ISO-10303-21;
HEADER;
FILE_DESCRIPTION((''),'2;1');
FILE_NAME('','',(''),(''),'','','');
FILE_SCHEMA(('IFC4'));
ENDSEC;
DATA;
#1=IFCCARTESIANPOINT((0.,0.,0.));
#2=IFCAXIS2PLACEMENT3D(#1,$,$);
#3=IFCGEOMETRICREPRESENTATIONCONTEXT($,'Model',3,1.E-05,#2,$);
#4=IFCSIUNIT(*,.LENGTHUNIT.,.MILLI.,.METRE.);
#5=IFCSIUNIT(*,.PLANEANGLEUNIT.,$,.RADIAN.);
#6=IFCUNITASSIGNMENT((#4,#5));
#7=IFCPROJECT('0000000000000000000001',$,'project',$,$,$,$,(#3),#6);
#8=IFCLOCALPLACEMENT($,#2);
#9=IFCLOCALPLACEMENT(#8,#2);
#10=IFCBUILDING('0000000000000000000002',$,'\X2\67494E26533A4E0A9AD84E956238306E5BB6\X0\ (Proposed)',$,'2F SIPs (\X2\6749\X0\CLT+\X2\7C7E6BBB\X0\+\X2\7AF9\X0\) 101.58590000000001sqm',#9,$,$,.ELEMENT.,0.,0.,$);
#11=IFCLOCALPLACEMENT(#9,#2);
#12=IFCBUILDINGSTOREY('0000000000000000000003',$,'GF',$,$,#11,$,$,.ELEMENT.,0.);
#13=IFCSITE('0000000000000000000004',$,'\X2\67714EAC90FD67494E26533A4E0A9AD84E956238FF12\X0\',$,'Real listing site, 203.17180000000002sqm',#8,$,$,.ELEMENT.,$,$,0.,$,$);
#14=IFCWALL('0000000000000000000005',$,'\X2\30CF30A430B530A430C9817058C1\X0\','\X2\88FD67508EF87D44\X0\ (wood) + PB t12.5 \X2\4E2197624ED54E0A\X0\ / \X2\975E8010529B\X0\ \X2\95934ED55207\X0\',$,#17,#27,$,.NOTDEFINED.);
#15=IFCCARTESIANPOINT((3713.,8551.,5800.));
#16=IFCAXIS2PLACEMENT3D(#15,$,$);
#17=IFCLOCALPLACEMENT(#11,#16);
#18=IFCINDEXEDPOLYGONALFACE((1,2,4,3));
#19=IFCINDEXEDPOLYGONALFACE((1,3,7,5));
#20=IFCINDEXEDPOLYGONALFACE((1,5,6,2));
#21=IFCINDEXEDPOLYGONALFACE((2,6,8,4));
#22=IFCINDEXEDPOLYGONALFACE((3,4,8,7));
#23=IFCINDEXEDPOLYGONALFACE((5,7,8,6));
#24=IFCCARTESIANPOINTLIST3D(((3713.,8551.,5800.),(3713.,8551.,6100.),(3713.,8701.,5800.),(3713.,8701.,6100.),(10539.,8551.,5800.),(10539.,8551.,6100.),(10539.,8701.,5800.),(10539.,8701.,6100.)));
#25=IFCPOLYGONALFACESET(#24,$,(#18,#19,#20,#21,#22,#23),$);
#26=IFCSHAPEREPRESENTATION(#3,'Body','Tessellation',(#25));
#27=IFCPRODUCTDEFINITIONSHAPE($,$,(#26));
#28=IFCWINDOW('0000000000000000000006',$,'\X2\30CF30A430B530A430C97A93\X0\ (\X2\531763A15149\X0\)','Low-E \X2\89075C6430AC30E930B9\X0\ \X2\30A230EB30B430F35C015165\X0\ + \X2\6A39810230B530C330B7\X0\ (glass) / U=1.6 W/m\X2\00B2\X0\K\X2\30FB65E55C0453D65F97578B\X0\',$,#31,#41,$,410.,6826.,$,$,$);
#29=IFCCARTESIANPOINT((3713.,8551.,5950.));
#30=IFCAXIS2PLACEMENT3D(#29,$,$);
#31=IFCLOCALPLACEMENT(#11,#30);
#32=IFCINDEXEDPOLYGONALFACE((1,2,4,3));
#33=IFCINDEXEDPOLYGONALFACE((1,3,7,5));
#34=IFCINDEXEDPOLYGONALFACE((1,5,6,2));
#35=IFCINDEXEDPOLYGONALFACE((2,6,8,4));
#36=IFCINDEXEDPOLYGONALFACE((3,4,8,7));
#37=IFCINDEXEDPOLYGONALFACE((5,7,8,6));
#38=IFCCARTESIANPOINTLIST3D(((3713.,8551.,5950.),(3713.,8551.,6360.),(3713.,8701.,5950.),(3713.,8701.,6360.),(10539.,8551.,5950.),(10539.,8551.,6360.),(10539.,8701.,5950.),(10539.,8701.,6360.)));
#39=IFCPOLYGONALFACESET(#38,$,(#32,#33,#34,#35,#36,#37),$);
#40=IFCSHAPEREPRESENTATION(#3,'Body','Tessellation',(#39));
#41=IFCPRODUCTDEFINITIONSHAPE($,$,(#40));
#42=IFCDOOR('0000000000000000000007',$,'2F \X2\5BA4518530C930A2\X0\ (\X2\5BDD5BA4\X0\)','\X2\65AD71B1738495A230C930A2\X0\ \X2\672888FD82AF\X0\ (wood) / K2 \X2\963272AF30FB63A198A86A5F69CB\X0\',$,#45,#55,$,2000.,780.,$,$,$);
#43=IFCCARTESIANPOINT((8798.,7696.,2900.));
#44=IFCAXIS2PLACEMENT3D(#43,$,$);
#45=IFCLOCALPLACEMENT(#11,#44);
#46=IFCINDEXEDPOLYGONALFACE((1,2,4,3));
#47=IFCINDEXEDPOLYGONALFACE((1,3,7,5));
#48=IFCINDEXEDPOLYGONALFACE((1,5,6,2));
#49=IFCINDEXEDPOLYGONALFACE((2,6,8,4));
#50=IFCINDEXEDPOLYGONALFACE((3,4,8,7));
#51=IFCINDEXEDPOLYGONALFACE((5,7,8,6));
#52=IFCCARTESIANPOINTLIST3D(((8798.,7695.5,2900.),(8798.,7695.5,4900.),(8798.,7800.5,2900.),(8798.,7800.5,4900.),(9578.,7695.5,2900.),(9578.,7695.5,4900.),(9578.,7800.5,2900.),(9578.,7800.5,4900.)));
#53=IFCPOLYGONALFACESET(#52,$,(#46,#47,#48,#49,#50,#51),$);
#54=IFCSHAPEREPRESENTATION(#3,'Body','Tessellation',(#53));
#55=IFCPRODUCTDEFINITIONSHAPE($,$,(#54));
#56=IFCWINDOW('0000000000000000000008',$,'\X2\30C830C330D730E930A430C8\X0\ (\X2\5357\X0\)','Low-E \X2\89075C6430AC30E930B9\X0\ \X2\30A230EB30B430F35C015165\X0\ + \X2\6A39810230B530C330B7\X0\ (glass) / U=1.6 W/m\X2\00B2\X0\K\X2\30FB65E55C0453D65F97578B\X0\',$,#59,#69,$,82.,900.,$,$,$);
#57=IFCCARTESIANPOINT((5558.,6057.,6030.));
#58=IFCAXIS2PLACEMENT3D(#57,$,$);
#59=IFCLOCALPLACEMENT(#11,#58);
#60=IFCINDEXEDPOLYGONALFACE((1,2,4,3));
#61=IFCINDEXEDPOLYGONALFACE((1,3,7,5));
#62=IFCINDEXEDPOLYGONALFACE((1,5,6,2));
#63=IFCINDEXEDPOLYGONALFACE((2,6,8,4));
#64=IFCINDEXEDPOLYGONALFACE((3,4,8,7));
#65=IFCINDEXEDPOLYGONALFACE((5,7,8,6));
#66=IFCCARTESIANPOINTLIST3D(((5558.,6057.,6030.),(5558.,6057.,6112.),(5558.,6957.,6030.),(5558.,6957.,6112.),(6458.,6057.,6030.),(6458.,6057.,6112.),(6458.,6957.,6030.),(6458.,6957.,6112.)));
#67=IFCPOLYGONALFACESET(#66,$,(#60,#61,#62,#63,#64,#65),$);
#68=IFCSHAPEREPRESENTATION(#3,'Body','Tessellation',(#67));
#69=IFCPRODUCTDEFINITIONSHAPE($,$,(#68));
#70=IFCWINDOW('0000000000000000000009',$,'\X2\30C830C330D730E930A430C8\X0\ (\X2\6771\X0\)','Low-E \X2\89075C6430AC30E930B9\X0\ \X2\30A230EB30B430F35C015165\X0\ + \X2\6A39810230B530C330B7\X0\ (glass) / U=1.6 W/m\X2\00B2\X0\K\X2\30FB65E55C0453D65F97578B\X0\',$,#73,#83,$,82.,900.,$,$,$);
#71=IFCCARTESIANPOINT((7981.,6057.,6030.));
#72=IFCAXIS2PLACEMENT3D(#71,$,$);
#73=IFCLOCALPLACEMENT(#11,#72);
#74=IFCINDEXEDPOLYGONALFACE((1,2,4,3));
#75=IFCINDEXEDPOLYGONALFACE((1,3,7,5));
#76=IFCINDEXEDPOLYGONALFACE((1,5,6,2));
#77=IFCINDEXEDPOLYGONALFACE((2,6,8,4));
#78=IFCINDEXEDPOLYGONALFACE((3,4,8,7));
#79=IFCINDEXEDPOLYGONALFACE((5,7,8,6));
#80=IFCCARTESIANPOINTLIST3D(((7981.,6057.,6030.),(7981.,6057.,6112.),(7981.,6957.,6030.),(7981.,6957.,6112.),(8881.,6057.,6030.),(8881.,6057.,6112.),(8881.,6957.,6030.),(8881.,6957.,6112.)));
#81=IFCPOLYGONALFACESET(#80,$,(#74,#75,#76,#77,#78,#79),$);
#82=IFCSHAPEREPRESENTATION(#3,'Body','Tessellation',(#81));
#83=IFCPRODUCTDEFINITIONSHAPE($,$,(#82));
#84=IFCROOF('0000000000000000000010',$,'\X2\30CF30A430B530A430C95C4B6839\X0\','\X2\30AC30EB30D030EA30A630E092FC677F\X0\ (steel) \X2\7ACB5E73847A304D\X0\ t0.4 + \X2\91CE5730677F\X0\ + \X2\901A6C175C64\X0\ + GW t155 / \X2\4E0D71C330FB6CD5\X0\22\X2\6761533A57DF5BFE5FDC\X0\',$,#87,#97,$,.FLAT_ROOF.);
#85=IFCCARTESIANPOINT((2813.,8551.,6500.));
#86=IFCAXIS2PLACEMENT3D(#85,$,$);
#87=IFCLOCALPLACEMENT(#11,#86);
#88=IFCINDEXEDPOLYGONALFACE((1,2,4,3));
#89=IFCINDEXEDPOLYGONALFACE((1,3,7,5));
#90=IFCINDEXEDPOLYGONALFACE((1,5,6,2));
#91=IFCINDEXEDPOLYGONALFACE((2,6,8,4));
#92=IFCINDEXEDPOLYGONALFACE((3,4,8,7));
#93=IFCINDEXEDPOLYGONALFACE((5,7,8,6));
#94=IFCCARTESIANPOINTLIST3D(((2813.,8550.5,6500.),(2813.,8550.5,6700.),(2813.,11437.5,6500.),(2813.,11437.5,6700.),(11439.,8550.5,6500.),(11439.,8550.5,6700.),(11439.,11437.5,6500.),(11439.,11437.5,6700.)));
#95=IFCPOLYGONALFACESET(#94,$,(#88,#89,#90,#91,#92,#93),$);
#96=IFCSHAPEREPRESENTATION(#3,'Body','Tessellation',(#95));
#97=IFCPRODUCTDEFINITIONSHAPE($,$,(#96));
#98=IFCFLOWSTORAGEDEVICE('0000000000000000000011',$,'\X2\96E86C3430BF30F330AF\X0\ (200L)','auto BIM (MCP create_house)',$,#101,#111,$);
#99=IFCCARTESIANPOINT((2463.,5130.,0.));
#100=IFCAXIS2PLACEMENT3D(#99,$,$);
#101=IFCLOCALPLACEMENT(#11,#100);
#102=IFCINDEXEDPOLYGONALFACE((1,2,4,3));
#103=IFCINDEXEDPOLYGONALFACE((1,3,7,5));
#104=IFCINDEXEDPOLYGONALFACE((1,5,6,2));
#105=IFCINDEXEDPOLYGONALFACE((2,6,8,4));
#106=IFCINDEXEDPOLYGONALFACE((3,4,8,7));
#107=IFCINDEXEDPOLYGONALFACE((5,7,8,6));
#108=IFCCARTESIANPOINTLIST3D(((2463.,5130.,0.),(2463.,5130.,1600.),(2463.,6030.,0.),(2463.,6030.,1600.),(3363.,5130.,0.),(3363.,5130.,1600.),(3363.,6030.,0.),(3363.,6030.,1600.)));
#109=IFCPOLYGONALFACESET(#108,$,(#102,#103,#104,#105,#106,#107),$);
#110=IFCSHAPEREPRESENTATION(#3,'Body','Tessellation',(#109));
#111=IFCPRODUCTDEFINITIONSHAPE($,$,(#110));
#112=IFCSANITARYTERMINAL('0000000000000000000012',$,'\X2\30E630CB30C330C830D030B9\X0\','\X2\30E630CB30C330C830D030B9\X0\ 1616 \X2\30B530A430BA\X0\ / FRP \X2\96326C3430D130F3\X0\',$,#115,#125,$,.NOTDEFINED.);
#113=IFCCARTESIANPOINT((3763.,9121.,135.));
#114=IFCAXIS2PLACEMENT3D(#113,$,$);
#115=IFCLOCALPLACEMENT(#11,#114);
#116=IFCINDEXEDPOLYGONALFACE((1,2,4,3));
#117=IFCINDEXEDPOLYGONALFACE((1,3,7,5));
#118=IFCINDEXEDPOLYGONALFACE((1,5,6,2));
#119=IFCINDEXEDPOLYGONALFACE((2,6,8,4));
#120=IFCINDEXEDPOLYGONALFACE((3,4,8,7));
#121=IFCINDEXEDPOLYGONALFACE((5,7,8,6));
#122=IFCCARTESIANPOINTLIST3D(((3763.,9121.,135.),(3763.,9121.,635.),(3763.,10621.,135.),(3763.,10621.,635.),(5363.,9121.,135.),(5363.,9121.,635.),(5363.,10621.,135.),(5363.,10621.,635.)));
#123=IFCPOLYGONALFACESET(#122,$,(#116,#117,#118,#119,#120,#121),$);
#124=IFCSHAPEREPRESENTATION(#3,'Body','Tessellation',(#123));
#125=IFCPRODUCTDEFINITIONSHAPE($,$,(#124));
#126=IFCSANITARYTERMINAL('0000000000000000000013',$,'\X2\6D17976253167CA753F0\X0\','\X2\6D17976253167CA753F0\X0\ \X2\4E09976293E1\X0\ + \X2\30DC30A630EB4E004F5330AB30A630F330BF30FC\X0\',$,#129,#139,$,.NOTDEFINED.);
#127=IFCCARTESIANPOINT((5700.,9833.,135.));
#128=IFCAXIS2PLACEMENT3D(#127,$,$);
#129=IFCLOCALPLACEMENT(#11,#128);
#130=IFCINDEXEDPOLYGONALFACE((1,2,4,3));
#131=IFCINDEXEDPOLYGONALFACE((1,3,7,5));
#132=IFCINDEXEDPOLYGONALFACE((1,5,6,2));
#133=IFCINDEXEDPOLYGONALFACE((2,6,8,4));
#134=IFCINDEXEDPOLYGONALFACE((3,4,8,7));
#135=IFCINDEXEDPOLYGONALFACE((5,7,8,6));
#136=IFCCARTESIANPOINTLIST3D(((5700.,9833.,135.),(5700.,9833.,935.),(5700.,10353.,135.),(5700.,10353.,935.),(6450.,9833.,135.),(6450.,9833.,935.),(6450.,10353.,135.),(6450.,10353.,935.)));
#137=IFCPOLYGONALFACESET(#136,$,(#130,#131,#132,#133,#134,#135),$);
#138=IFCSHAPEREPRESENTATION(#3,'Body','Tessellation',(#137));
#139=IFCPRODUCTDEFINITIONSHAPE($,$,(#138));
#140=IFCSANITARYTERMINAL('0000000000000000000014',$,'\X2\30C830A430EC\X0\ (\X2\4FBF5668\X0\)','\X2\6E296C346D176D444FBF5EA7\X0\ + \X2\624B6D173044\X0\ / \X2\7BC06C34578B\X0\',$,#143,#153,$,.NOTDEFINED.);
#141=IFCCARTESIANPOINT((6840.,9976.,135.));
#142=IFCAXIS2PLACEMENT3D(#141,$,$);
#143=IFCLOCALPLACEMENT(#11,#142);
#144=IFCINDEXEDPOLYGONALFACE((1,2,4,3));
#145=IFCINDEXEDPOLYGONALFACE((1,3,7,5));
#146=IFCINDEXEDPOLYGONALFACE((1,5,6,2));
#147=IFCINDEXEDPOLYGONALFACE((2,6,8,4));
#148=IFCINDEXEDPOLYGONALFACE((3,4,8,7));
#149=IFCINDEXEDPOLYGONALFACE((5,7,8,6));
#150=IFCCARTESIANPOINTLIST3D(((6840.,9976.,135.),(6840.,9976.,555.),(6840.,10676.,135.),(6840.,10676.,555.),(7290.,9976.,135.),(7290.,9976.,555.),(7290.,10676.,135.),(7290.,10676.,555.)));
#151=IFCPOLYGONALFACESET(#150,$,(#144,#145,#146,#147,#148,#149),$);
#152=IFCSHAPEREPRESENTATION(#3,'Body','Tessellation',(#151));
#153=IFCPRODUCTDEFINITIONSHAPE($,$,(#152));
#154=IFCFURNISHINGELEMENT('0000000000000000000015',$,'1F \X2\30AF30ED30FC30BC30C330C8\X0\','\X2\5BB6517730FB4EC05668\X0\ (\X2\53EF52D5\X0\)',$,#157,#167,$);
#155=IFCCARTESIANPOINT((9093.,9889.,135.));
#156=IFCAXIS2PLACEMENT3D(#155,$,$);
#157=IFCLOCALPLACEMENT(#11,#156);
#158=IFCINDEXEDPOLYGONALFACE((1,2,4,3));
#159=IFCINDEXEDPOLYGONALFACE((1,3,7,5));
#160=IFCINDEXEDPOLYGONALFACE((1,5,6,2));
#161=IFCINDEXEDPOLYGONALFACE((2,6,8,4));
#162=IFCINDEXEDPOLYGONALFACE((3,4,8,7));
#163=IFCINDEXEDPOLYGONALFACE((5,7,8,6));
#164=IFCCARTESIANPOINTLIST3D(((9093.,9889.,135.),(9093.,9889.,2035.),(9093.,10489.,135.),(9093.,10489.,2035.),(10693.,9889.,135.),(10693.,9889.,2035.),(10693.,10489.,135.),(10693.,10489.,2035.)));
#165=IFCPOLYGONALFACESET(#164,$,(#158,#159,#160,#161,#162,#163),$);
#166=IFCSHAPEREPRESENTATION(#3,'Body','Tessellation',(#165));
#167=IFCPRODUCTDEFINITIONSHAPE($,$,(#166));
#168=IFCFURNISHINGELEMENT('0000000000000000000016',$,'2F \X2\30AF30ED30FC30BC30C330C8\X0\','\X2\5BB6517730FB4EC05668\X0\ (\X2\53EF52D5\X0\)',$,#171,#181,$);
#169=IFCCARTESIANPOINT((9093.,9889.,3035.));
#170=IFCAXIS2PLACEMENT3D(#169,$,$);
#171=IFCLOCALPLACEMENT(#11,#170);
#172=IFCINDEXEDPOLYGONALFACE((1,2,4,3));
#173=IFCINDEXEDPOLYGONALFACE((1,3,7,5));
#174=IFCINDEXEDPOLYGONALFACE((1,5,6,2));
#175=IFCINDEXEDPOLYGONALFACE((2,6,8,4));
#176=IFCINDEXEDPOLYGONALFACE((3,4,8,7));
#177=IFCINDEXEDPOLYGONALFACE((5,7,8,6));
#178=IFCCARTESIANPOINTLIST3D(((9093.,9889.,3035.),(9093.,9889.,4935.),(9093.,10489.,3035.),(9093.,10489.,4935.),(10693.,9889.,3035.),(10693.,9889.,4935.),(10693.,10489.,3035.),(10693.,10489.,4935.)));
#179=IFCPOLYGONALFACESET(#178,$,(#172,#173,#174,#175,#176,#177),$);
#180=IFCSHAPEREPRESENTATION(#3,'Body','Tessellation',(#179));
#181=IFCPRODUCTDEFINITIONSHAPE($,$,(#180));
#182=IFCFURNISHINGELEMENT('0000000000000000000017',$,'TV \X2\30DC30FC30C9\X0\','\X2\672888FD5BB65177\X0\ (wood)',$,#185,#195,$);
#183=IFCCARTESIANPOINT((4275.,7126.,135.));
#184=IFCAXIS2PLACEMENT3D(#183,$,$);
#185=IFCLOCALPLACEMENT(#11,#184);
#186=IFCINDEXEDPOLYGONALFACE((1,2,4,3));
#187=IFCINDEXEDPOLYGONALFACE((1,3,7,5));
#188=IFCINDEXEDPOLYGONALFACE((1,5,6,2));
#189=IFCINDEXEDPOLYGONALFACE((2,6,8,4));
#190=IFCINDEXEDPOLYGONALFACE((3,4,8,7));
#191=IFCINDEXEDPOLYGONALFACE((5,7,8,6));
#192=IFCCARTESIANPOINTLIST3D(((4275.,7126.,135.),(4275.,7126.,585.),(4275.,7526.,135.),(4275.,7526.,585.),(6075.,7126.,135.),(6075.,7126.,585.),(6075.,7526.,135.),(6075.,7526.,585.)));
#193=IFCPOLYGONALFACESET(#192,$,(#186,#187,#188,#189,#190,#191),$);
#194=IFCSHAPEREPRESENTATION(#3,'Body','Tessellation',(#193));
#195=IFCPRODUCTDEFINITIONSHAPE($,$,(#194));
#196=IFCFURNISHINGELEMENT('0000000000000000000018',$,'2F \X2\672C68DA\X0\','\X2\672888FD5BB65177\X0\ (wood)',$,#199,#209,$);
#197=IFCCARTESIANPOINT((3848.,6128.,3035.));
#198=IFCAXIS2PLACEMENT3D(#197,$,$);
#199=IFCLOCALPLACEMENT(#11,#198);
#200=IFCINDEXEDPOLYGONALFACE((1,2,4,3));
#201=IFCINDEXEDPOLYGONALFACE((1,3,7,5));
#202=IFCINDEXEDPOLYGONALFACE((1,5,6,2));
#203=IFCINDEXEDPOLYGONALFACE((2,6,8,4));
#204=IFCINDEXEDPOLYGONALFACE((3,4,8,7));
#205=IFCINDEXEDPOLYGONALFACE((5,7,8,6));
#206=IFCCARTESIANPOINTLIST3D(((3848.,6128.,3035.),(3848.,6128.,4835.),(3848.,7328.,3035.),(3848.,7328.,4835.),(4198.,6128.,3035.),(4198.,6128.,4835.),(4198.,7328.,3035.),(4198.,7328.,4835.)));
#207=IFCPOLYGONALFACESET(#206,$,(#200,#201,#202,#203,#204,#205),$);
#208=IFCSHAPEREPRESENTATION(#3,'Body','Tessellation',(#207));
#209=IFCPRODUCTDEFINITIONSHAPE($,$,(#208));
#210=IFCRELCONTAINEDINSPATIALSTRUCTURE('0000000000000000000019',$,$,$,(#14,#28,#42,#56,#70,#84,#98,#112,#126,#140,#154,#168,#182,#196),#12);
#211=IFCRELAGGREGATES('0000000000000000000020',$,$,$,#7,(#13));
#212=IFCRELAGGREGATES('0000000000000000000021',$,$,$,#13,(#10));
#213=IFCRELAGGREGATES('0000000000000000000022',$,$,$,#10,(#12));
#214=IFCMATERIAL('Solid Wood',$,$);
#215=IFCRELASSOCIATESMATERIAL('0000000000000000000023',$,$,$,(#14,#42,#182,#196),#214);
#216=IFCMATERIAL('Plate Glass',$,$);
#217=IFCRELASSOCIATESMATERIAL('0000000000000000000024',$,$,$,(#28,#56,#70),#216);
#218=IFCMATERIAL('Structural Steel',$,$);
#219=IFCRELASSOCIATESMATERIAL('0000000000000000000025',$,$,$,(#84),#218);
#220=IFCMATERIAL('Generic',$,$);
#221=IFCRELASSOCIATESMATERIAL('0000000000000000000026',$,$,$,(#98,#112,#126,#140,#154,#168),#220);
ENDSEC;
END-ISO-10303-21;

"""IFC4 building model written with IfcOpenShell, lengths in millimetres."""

from ifc_helpers import new_model, si_unit, frame, frame_2d, origin, place, context, project, spatial, rectangle, extrude, material, element, fill, save


model = new_model("IFC4")

# Units and contexts
model_context = context("Model", 3, precision=1e-05, world=origin())
ifc_project = project(units=[si_unit("LENGTHUNIT", "METRE", prefix="MILLI"), si_unit("PLANEANGLEUNIT", "RADIAN")], contexts=[model_context])

# Site, building, storey
site_placement = place(None, origin())
site = spatial("IfcSite", under=ifc_project, at=site_placement, Name="東京都杉並区上高井戸２", ObjectType="Real listing site, 203.17180000000002sqm", CompositionType="ELEMENT", RefElevation=0.0)
building_placement = place(site_placement, origin())
building = spatial("IfcBuilding", under=site, at=building_placement, Name="杉並区上高井戸の家 (Proposed)", ObjectType="2F SIPs (杉CLT+籾殻+竹) 101.58590000000001sqm", CompositionType="ELEMENT", ElevationOfRefHeight=0.0, ElevationOfTerrain=0.0)
storey_placement = place(building_placement, origin())
storey = spatial("IfcBuildingStorey", under=building, at=storey_placement, Name="GF", CompositionType="ELEMENT", Elevation=0.0)

# Shared definitions
ifc_material_1 = material(Name="Solid Wood")
ifc_material_2 = material(Name="Plate Glass")

# Wall, opening, window
wall_1_placement = place(storey_placement, frame((3713.0, 8551.0, 5800.0)))
wall_1 = element("IfcWall", 1, at=wall_1_placement, inside=storey, material=ifc_material_1, Name="ハイサイド腰壁", Description="製材軸組 (wood) + PB t12.5 両面仕上 / 非耐力 間仕切", PredefinedType="NOTDEFINED", context=model_context, shape_type="SweptSolid", body=[
    extrude(rectangle(XDim=6826.0, YDim=150.0, at=frame_2d((3413.0, 75.0))), frame((3713.0, 8551.0, 5800.0)), (0.0, 0.0, 1.0), 700.0),
])
opening_1_placement = place(storey_placement, frame((3713.0, 8551.0, 5950.0)))
opening_1 = element("IfcOpeningElement", 2, at=opening_1_placement, cuts=wall_1, PredefinedType="NOTDEFINED", context=model_context, shape_type="SweptSolid", body=[
    extrude(rectangle(XDim=6826.0, YDim=150.0, at=frame_2d((3413.0, 75.0))), frame((3713.0, 8551.0, 5950.0)), (0.0, 0.0, 1.0), 410.0),
])
window_1_placement = place(storey_placement, frame((3713.0, 8551.0, 5950.0)))
window_1 = element("IfcWindow", 3, at=window_1_placement, inside=storey, material=ifc_material_2, Name="ハイサイド窓 (北採光)", Description="Low-E 複層ガラス アルゴン封入 + 樹脂サッシ (glass) / U=1.6 W/m²K・日射取得型", OverallHeight=410.0, OverallWidth=6826.0, context=model_context, shape_type="SweptSolid", body=[
    extrude(rectangle(XDim=6826.0, YDim=150.0, at=frame_2d((3413.0, 75.0))), frame((3713.0, 8551.0, 5950.0)), (0.0, 0.0, 1.0), 410.0),
])
fill(opening_1, window_1)

# Door
door_1_placement = place(storey_placement, frame((8798.0, 7696.0, 2900.0)))
element("IfcDoor", 4, at=door_1_placement, inside=storey, material=ifc_material_1, Name="2F 室内ドア (寝室)", Description="断熱玄関ドア 木製芯 (wood) / K2 防犯・採風機構", OverallHeight=2000.0, OverallWidth=780.0, context=model_context, shape_type="SweptSolid", body=[
    extrude(rectangle(XDim=780.0, YDim=105.0, at=frame_2d((390.0, 52.0))), frame((8798.0, 7696.0, 2900.0)), (0.0, 0.0, 1.0), 2000.0),
])

# Windows
window_2_placement = place(storey_placement, frame((5558.0, 6057.0, 6030.0)))
element("IfcWindow", 5, at=window_2_placement, inside=storey, material=ifc_material_2, Name="トップライト (南)", Description="Low-E 複層ガラス アルゴン封入 + 樹脂サッシ (glass) / U=1.6 W/m²K・日射取得型", OverallHeight=82.0, OverallWidth=900.0, context=model_context, shape_type="SweptSolid", body=[
    extrude(rectangle(XDim=900.0, YDim=900.0, at=frame_2d((450.0, 450.0))), frame((5558.0, 6057.0, 6030.0)), (0.0, 0.0, 1.0), 82.0),
])
window_3_placement = place(storey_placement, frame((7981.0, 6057.0, 6030.0)))
element("IfcWindow", 6, at=window_3_placement, inside=storey, material=ifc_material_2, Name="トップライト (東)", Description="Low-E 複層ガラス アルゴン封入 + 樹脂サッシ (glass) / U=1.6 W/m²K・日射取得型", OverallHeight=82.0, OverallWidth=900.0, context=model_context, shape_type="SweptSolid", body=[
    extrude(rectangle(XDim=900.0, YDim=900.0, at=frame_2d((450.0, 450.0))), frame((7981.0, 6057.0, 6030.0)), (0.0, 0.0, 1.0), 82.0),
])

# Roof
ifc_material_3 = material(Name="Structural Steel")
roof_placement = place(storey_placement, frame((2813.0, 8551.0, 6500.0)))
element("IfcRoof", 7, at=roof_placement, inside=storey, material=ifc_material_3, Name="ハイサイド屋根", Description="ガルバリウム鋼板 (steel) 立平葺き t0.4 + 野地板 + 通気層 + GW t155 / 不燃・法22条区域対応", PredefinedType="FLAT_ROOF", context=model_context, shape_type="SweptSolid", body=[
    extrude(rectangle(XDim=8626.0, YDim=2887.0, at=frame_2d((4313.0, 1443.0))), frame((2813.0, 8551.0, 6500.0)), (0.0, 0.0, 1.0), 200.0),
])

# Flow storage device
ifc_material_4 = material(Name="Generic")
flow_storage_device_placement = place(storey_placement, frame((2463.0, 5130.0, 0.0)))
element("IfcFlowStorageDevice", 8, at=flow_storage_device_placement, inside=storey, material=ifc_material_4, Name="雨水タンク (200L)", Description="auto BIM (MCP create_house)", context=model_context, shape_type="SweptSolid", body=[
    extrude(rectangle(XDim=900.0, YDim=900.0, at=frame_2d((450.0, 450.0))), frame((2463.0, 5130.0, 0.0)), (0.0, 0.0, 1.0), 1600.0),
])

# Sanitary terminals
sanitary_terminal_1_placement = place(storey_placement, frame((3763.0, 9121.0, 135.0)))
element("IfcSanitaryTerminal", 9, at=sanitary_terminal_1_placement, inside=storey, material=ifc_material_4, Name="ユニットバス", Description="ユニットバス 1616 サイズ / FRP 防水パン", PredefinedType="NOTDEFINED", context=model_context, shape_type="SweptSolid", body=[
    extrude(rectangle(XDim=1600.0, YDim=1500.0, at=frame_2d((800.0, 750.0))), frame((3763.0, 9121.0, 135.0)), (0.0, 0.0, 1.0), 500.0),
])
sanitary_terminal_2_placement = place(storey_placement, frame((5700.0, 9833.0, 135.0)))
element("IfcSanitaryTerminal", 10, at=sanitary_terminal_2_placement, inside=storey, material=ifc_material_4, Name="洗面化粧台", Description="洗面化粧台 三面鏡 + ボウル一体カウンター", PredefinedType="NOTDEFINED", context=model_context, shape_type="SweptSolid", body=[
    extrude(rectangle(XDim=750.0, YDim=520.0, at=frame_2d((375.0, 260.0))), frame((5700.0, 9833.0, 135.0)), (0.0, 0.0, 1.0), 800.0),
])
sanitary_terminal_3_placement = place(storey_placement, frame((6840.0, 9976.0, 135.0)))
element("IfcSanitaryTerminal", 11, at=sanitary_terminal_3_placement, inside=storey, material=ifc_material_4, Name="トイレ (便器)", Description="温水洗浄便座 + 手洗い / 節水型", PredefinedType="NOTDEFINED", context=model_context, shape_type="SweptSolid", body=[
    extrude(rectangle(XDim=450.0, YDim=700.0, at=frame_2d((225.0, 350.0))), frame((6840.0, 9976.0, 135.0)), (0.0, 0.0, 1.0), 420.0),
])

# Furnishing elements
furnishing_1_placement = place(storey_placement, frame((9093.0, 9889.0, 135.0)))
element("IfcFurnishingElement", 12, at=furnishing_1_placement, inside=storey, material=ifc_material_4, Name="1F クローゼット", Description="家具・什器 (可動)", context=model_context, shape_type="SweptSolid", body=[
    extrude(rectangle(XDim=1600.0, YDim=600.0, at=frame_2d((800.0, 300.0))), frame((9093.0, 9889.0, 135.0)), (0.0, 0.0, 1.0), 1900.0),
])
furnishing_2_placement = place(storey_placement, frame((9093.0, 9889.0, 3035.0)))
element("IfcFurnishingElement", 13, at=furnishing_2_placement, inside=storey, material=ifc_material_4, Name="2F クローゼット", Description="家具・什器 (可動)", context=model_context, shape_type="SweptSolid", body=[
    extrude(rectangle(XDim=1600.0, YDim=600.0, at=frame_2d((800.0, 300.0))), frame((9093.0, 9889.0, 3035.0)), (0.0, 0.0, 1.0), 1900.0),
])
furnishing_3_placement = place(storey_placement, frame((4275.0, 7126.0, 135.0)))
element("IfcFurnishingElement", 14, at=furnishing_3_placement, inside=storey, material=ifc_material_1, Name="TV ボード", Description="木製家具 (wood)", context=model_context, shape_type="SweptSolid", body=[
    extrude(rectangle(XDim=1800.0, YDim=400.0, at=frame_2d((900.0, 200.0))), frame((4275.0, 7126.0, 135.0)), (0.0, 0.0, 1.0), 450.0),
])
furnishing_4_placement = place(storey_placement, frame((3848.0, 6128.0, 3035.0)))
element("IfcFurnishingElement", 15, at=furnishing_4_placement, inside=storey, material=ifc_material_1, Name="2F 本棚", Description="木製家具 (wood)", context=model_context, shape_type="SweptSolid", body=[
    extrude(rectangle(XDim=350.0, YDim=1200.0, at=frame_2d((175.0, 600.0))), frame((3848.0, 6128.0, 3035.0)), (0.0, 0.0, 1.0), 1800.0),
])

save(model, "model.ifc")
